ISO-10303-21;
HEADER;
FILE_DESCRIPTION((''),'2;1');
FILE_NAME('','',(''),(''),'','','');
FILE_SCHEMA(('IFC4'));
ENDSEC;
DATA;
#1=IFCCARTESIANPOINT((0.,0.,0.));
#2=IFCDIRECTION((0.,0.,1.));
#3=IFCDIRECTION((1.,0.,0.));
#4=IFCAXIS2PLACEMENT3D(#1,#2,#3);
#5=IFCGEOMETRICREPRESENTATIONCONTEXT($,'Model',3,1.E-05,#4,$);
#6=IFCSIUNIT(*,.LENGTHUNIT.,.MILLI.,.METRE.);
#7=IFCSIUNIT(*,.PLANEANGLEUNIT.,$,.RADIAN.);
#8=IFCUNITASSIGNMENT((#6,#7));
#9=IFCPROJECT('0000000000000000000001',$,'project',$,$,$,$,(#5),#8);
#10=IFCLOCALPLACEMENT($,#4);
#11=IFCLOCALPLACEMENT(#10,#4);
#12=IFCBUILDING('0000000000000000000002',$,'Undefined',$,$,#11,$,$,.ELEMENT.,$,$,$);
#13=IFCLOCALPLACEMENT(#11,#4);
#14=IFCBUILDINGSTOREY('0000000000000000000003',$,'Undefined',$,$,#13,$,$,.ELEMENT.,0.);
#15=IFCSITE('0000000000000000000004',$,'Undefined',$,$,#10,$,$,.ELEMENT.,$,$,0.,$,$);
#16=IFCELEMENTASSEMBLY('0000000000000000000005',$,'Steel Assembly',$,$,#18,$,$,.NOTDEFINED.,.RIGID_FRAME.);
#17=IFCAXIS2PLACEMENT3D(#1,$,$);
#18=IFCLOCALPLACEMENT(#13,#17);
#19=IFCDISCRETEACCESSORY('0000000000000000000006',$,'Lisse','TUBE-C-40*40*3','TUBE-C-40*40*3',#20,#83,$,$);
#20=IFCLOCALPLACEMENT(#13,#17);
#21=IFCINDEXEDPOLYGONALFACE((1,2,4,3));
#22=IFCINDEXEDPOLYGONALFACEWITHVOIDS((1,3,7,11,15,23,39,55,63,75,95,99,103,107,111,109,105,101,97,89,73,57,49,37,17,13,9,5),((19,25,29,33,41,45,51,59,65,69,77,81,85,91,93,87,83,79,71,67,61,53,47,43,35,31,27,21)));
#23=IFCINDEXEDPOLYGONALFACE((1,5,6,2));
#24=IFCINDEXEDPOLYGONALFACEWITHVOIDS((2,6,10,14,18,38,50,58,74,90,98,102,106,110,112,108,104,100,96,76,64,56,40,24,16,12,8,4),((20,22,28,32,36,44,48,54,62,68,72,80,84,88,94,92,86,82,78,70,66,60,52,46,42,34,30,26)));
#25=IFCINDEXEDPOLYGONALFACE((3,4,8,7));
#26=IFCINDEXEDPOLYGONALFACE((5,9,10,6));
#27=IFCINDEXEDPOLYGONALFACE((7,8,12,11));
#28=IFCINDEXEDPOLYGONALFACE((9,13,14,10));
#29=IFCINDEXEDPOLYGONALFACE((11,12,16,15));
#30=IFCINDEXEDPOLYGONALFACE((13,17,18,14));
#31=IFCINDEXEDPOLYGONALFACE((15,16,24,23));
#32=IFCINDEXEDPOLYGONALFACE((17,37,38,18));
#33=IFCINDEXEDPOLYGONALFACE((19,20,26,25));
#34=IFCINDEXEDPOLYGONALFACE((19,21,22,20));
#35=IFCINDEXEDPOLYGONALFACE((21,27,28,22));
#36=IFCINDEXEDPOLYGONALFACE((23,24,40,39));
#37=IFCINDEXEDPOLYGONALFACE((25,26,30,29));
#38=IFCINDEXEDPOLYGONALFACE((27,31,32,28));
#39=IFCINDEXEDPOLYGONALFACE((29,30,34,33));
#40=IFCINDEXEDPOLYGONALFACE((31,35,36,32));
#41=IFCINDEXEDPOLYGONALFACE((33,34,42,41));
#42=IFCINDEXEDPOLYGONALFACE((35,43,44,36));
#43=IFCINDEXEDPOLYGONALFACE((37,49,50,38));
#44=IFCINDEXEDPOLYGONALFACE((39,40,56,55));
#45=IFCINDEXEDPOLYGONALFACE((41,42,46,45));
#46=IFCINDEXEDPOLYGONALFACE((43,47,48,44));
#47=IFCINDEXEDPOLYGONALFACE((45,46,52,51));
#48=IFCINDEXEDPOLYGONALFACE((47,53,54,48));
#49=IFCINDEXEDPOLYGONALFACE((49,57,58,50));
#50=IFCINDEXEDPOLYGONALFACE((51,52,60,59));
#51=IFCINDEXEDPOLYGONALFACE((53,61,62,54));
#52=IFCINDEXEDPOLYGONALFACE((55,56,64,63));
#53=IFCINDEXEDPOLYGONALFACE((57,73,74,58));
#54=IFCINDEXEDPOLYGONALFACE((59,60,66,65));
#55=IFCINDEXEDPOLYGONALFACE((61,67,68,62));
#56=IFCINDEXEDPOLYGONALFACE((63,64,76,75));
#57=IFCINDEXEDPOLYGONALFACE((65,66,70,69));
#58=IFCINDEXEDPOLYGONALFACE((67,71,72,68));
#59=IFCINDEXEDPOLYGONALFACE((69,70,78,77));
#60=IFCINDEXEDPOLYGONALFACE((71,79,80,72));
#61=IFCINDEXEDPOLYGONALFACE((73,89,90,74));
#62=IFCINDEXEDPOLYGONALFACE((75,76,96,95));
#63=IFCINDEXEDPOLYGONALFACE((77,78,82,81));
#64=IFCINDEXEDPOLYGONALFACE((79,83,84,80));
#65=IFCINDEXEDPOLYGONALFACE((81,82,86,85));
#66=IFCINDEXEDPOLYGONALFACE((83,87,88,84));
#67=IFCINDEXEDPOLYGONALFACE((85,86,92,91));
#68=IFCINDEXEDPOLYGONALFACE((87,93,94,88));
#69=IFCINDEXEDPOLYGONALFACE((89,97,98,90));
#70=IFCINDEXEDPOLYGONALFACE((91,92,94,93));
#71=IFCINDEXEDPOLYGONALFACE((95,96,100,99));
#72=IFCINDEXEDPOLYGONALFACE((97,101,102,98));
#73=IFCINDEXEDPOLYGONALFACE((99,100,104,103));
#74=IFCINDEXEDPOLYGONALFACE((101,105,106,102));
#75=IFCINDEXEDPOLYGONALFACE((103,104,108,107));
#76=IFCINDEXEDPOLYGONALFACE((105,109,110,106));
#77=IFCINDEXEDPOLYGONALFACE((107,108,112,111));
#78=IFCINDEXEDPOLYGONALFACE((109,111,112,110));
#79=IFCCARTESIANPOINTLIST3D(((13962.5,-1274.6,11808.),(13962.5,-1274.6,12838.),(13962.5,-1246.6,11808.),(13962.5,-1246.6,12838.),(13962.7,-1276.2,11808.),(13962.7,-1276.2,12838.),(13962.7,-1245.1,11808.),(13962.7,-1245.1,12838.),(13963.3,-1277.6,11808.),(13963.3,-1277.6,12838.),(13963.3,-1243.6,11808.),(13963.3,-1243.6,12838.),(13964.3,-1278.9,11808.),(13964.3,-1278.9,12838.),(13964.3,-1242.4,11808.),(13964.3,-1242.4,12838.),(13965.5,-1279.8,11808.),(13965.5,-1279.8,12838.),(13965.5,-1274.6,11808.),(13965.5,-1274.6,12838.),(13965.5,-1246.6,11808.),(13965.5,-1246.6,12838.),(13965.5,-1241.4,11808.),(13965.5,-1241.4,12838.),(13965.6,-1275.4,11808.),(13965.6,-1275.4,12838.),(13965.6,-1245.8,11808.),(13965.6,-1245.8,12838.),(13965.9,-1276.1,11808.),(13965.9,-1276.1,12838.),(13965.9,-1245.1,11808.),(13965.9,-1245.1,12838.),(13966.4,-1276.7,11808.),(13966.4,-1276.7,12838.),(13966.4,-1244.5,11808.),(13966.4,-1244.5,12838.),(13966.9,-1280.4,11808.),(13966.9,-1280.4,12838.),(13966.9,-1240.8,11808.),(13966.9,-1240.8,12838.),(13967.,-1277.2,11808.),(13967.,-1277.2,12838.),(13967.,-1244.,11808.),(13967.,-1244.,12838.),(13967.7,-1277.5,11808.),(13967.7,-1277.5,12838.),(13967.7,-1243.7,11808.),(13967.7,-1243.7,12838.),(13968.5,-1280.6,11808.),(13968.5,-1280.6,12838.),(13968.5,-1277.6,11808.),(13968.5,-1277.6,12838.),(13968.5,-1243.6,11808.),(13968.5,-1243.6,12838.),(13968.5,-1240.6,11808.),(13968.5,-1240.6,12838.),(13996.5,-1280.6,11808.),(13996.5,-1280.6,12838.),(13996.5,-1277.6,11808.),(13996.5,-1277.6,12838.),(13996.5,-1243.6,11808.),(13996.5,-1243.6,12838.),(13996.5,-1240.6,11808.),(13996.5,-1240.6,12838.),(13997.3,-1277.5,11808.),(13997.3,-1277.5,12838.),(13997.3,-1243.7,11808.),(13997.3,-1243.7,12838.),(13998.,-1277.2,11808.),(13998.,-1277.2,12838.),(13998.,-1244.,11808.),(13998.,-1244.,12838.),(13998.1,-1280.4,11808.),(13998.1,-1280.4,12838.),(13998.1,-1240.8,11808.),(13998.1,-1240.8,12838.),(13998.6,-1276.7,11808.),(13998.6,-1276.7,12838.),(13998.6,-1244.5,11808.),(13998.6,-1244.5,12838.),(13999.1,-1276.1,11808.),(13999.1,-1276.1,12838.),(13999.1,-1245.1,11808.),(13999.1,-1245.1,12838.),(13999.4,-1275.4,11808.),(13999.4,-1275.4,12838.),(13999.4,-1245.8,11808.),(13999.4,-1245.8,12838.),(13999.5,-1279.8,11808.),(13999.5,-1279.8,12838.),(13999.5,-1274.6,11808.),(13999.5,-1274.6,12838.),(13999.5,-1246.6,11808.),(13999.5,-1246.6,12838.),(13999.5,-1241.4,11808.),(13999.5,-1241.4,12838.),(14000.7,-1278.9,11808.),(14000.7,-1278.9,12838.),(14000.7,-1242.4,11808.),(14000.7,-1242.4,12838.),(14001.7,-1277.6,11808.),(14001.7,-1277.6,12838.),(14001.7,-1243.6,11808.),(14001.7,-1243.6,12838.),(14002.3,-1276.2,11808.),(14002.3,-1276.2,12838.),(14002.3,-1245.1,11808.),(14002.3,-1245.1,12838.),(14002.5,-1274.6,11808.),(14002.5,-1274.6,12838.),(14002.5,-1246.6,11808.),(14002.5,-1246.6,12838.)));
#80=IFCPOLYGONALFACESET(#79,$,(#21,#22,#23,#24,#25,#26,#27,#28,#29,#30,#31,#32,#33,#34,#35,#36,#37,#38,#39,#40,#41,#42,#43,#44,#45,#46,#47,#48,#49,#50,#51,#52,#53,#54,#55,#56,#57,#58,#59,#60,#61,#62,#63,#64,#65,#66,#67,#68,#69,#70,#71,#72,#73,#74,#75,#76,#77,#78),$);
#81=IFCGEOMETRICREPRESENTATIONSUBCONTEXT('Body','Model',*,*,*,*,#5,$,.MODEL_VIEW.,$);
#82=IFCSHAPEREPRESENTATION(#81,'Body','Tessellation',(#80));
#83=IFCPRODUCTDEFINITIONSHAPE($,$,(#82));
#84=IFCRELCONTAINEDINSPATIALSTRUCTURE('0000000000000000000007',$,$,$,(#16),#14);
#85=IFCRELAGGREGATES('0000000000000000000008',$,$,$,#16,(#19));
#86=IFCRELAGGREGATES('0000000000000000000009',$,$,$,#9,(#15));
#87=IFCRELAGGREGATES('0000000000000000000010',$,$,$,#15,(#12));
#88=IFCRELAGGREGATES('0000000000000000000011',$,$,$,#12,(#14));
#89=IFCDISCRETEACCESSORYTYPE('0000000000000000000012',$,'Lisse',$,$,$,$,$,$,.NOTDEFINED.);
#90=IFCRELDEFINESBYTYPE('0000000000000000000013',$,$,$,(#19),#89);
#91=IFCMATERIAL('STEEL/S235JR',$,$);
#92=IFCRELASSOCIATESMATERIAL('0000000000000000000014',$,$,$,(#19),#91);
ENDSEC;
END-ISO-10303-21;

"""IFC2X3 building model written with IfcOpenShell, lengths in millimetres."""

from ifc_helpers import new_model, si_unit, frame, origin_with_axes, origin_2d_with_axis, place, context, subcontext, project, spatial, hollow_rectangle, extrude, material, type_object, element, aggregate, save


model = new_model("IFC2X3")

# Units and contexts
model_context = context("Model", 3, precision=1e-05, world=origin_with_axes())
body_context = subcontext(model_context, "Body", "Model", "MODEL_VIEW")
ifc_project = project(units=[si_unit("LENGTHUNIT", "METRE", prefix="MILLI"), si_unit("PLANEANGLEUNIT", "RADIAN")], contexts=[model_context])

# Site, building, storey
site_placement = place(None, origin_with_axes())
site = spatial("IfcSite", under=ifc_project, at=site_placement, Name="Undefined", CompositionType="ELEMENT", RefElevation=0.0)
building_placement = place(site_placement, origin_with_axes())
building = spatial("IfcBuilding", under=site, at=building_placement, Name="Undefined", CompositionType="ELEMENT")
storey_placement = place(building_placement, origin_with_axes())
storey = spatial("IfcBuildingStorey", under=building, at=storey_placement, Name="Undefined", CompositionType="ELEMENT", Elevation=0.0)

# Shared definitions
ifc_material_1 = material(Name="STEEL/S235JR")

# Element assembly
assembly_1_placement = place(storey_placement, origin_with_axes())
assembly_1 = element("IfcElementAssembly", 1, at=assembly_1_placement, inside=storey, Name="Steel Assembly", AssemblyPlace="NOTDEFINED", PredefinedType="RIGID_FRAME")

# Discrete accessory
discrete_accessory_type_1 = type_object("IfcDiscreteAccessoryType", Name="Lisse")
discrete_accessory_1_placement = place(assembly_1_placement, frame((13982.5, -1260.6, 12838.0), z_axis=(0.0, 1.0, 0.0), x_axis=(0.0, 0.0, -1.0)))
discrete_accessory_1 = element("IfcDiscreteAccessory", 2, at=discrete_accessory_1_placement, type_object=discrete_accessory_type_1, material=ifc_material_1, Name="Lisse", Description="TUBE-C-40*40*3", ObjectType="TUBE-C-40*40*3", context=body_context, shape_type="SweptSolid", body=[
    extrude(hollow_rectangle(XDim=40.0, YDim=40.0, WallThickness=3.0, InnerFilletRadius=3.0, OuterFilletRadius=6.0, at=origin_2d_with_axis()), frame((1030.0, 0.0, 0.0), z_axis=(-1.0, 0.0, 0.0), x_axis=(0.0, -1.0, 0.0)), (0.0, 0.0, 1.0), 1030.0),
])
aggregate(assembly_1, [discrete_accessory_1])

save(model, "model.ifc")
